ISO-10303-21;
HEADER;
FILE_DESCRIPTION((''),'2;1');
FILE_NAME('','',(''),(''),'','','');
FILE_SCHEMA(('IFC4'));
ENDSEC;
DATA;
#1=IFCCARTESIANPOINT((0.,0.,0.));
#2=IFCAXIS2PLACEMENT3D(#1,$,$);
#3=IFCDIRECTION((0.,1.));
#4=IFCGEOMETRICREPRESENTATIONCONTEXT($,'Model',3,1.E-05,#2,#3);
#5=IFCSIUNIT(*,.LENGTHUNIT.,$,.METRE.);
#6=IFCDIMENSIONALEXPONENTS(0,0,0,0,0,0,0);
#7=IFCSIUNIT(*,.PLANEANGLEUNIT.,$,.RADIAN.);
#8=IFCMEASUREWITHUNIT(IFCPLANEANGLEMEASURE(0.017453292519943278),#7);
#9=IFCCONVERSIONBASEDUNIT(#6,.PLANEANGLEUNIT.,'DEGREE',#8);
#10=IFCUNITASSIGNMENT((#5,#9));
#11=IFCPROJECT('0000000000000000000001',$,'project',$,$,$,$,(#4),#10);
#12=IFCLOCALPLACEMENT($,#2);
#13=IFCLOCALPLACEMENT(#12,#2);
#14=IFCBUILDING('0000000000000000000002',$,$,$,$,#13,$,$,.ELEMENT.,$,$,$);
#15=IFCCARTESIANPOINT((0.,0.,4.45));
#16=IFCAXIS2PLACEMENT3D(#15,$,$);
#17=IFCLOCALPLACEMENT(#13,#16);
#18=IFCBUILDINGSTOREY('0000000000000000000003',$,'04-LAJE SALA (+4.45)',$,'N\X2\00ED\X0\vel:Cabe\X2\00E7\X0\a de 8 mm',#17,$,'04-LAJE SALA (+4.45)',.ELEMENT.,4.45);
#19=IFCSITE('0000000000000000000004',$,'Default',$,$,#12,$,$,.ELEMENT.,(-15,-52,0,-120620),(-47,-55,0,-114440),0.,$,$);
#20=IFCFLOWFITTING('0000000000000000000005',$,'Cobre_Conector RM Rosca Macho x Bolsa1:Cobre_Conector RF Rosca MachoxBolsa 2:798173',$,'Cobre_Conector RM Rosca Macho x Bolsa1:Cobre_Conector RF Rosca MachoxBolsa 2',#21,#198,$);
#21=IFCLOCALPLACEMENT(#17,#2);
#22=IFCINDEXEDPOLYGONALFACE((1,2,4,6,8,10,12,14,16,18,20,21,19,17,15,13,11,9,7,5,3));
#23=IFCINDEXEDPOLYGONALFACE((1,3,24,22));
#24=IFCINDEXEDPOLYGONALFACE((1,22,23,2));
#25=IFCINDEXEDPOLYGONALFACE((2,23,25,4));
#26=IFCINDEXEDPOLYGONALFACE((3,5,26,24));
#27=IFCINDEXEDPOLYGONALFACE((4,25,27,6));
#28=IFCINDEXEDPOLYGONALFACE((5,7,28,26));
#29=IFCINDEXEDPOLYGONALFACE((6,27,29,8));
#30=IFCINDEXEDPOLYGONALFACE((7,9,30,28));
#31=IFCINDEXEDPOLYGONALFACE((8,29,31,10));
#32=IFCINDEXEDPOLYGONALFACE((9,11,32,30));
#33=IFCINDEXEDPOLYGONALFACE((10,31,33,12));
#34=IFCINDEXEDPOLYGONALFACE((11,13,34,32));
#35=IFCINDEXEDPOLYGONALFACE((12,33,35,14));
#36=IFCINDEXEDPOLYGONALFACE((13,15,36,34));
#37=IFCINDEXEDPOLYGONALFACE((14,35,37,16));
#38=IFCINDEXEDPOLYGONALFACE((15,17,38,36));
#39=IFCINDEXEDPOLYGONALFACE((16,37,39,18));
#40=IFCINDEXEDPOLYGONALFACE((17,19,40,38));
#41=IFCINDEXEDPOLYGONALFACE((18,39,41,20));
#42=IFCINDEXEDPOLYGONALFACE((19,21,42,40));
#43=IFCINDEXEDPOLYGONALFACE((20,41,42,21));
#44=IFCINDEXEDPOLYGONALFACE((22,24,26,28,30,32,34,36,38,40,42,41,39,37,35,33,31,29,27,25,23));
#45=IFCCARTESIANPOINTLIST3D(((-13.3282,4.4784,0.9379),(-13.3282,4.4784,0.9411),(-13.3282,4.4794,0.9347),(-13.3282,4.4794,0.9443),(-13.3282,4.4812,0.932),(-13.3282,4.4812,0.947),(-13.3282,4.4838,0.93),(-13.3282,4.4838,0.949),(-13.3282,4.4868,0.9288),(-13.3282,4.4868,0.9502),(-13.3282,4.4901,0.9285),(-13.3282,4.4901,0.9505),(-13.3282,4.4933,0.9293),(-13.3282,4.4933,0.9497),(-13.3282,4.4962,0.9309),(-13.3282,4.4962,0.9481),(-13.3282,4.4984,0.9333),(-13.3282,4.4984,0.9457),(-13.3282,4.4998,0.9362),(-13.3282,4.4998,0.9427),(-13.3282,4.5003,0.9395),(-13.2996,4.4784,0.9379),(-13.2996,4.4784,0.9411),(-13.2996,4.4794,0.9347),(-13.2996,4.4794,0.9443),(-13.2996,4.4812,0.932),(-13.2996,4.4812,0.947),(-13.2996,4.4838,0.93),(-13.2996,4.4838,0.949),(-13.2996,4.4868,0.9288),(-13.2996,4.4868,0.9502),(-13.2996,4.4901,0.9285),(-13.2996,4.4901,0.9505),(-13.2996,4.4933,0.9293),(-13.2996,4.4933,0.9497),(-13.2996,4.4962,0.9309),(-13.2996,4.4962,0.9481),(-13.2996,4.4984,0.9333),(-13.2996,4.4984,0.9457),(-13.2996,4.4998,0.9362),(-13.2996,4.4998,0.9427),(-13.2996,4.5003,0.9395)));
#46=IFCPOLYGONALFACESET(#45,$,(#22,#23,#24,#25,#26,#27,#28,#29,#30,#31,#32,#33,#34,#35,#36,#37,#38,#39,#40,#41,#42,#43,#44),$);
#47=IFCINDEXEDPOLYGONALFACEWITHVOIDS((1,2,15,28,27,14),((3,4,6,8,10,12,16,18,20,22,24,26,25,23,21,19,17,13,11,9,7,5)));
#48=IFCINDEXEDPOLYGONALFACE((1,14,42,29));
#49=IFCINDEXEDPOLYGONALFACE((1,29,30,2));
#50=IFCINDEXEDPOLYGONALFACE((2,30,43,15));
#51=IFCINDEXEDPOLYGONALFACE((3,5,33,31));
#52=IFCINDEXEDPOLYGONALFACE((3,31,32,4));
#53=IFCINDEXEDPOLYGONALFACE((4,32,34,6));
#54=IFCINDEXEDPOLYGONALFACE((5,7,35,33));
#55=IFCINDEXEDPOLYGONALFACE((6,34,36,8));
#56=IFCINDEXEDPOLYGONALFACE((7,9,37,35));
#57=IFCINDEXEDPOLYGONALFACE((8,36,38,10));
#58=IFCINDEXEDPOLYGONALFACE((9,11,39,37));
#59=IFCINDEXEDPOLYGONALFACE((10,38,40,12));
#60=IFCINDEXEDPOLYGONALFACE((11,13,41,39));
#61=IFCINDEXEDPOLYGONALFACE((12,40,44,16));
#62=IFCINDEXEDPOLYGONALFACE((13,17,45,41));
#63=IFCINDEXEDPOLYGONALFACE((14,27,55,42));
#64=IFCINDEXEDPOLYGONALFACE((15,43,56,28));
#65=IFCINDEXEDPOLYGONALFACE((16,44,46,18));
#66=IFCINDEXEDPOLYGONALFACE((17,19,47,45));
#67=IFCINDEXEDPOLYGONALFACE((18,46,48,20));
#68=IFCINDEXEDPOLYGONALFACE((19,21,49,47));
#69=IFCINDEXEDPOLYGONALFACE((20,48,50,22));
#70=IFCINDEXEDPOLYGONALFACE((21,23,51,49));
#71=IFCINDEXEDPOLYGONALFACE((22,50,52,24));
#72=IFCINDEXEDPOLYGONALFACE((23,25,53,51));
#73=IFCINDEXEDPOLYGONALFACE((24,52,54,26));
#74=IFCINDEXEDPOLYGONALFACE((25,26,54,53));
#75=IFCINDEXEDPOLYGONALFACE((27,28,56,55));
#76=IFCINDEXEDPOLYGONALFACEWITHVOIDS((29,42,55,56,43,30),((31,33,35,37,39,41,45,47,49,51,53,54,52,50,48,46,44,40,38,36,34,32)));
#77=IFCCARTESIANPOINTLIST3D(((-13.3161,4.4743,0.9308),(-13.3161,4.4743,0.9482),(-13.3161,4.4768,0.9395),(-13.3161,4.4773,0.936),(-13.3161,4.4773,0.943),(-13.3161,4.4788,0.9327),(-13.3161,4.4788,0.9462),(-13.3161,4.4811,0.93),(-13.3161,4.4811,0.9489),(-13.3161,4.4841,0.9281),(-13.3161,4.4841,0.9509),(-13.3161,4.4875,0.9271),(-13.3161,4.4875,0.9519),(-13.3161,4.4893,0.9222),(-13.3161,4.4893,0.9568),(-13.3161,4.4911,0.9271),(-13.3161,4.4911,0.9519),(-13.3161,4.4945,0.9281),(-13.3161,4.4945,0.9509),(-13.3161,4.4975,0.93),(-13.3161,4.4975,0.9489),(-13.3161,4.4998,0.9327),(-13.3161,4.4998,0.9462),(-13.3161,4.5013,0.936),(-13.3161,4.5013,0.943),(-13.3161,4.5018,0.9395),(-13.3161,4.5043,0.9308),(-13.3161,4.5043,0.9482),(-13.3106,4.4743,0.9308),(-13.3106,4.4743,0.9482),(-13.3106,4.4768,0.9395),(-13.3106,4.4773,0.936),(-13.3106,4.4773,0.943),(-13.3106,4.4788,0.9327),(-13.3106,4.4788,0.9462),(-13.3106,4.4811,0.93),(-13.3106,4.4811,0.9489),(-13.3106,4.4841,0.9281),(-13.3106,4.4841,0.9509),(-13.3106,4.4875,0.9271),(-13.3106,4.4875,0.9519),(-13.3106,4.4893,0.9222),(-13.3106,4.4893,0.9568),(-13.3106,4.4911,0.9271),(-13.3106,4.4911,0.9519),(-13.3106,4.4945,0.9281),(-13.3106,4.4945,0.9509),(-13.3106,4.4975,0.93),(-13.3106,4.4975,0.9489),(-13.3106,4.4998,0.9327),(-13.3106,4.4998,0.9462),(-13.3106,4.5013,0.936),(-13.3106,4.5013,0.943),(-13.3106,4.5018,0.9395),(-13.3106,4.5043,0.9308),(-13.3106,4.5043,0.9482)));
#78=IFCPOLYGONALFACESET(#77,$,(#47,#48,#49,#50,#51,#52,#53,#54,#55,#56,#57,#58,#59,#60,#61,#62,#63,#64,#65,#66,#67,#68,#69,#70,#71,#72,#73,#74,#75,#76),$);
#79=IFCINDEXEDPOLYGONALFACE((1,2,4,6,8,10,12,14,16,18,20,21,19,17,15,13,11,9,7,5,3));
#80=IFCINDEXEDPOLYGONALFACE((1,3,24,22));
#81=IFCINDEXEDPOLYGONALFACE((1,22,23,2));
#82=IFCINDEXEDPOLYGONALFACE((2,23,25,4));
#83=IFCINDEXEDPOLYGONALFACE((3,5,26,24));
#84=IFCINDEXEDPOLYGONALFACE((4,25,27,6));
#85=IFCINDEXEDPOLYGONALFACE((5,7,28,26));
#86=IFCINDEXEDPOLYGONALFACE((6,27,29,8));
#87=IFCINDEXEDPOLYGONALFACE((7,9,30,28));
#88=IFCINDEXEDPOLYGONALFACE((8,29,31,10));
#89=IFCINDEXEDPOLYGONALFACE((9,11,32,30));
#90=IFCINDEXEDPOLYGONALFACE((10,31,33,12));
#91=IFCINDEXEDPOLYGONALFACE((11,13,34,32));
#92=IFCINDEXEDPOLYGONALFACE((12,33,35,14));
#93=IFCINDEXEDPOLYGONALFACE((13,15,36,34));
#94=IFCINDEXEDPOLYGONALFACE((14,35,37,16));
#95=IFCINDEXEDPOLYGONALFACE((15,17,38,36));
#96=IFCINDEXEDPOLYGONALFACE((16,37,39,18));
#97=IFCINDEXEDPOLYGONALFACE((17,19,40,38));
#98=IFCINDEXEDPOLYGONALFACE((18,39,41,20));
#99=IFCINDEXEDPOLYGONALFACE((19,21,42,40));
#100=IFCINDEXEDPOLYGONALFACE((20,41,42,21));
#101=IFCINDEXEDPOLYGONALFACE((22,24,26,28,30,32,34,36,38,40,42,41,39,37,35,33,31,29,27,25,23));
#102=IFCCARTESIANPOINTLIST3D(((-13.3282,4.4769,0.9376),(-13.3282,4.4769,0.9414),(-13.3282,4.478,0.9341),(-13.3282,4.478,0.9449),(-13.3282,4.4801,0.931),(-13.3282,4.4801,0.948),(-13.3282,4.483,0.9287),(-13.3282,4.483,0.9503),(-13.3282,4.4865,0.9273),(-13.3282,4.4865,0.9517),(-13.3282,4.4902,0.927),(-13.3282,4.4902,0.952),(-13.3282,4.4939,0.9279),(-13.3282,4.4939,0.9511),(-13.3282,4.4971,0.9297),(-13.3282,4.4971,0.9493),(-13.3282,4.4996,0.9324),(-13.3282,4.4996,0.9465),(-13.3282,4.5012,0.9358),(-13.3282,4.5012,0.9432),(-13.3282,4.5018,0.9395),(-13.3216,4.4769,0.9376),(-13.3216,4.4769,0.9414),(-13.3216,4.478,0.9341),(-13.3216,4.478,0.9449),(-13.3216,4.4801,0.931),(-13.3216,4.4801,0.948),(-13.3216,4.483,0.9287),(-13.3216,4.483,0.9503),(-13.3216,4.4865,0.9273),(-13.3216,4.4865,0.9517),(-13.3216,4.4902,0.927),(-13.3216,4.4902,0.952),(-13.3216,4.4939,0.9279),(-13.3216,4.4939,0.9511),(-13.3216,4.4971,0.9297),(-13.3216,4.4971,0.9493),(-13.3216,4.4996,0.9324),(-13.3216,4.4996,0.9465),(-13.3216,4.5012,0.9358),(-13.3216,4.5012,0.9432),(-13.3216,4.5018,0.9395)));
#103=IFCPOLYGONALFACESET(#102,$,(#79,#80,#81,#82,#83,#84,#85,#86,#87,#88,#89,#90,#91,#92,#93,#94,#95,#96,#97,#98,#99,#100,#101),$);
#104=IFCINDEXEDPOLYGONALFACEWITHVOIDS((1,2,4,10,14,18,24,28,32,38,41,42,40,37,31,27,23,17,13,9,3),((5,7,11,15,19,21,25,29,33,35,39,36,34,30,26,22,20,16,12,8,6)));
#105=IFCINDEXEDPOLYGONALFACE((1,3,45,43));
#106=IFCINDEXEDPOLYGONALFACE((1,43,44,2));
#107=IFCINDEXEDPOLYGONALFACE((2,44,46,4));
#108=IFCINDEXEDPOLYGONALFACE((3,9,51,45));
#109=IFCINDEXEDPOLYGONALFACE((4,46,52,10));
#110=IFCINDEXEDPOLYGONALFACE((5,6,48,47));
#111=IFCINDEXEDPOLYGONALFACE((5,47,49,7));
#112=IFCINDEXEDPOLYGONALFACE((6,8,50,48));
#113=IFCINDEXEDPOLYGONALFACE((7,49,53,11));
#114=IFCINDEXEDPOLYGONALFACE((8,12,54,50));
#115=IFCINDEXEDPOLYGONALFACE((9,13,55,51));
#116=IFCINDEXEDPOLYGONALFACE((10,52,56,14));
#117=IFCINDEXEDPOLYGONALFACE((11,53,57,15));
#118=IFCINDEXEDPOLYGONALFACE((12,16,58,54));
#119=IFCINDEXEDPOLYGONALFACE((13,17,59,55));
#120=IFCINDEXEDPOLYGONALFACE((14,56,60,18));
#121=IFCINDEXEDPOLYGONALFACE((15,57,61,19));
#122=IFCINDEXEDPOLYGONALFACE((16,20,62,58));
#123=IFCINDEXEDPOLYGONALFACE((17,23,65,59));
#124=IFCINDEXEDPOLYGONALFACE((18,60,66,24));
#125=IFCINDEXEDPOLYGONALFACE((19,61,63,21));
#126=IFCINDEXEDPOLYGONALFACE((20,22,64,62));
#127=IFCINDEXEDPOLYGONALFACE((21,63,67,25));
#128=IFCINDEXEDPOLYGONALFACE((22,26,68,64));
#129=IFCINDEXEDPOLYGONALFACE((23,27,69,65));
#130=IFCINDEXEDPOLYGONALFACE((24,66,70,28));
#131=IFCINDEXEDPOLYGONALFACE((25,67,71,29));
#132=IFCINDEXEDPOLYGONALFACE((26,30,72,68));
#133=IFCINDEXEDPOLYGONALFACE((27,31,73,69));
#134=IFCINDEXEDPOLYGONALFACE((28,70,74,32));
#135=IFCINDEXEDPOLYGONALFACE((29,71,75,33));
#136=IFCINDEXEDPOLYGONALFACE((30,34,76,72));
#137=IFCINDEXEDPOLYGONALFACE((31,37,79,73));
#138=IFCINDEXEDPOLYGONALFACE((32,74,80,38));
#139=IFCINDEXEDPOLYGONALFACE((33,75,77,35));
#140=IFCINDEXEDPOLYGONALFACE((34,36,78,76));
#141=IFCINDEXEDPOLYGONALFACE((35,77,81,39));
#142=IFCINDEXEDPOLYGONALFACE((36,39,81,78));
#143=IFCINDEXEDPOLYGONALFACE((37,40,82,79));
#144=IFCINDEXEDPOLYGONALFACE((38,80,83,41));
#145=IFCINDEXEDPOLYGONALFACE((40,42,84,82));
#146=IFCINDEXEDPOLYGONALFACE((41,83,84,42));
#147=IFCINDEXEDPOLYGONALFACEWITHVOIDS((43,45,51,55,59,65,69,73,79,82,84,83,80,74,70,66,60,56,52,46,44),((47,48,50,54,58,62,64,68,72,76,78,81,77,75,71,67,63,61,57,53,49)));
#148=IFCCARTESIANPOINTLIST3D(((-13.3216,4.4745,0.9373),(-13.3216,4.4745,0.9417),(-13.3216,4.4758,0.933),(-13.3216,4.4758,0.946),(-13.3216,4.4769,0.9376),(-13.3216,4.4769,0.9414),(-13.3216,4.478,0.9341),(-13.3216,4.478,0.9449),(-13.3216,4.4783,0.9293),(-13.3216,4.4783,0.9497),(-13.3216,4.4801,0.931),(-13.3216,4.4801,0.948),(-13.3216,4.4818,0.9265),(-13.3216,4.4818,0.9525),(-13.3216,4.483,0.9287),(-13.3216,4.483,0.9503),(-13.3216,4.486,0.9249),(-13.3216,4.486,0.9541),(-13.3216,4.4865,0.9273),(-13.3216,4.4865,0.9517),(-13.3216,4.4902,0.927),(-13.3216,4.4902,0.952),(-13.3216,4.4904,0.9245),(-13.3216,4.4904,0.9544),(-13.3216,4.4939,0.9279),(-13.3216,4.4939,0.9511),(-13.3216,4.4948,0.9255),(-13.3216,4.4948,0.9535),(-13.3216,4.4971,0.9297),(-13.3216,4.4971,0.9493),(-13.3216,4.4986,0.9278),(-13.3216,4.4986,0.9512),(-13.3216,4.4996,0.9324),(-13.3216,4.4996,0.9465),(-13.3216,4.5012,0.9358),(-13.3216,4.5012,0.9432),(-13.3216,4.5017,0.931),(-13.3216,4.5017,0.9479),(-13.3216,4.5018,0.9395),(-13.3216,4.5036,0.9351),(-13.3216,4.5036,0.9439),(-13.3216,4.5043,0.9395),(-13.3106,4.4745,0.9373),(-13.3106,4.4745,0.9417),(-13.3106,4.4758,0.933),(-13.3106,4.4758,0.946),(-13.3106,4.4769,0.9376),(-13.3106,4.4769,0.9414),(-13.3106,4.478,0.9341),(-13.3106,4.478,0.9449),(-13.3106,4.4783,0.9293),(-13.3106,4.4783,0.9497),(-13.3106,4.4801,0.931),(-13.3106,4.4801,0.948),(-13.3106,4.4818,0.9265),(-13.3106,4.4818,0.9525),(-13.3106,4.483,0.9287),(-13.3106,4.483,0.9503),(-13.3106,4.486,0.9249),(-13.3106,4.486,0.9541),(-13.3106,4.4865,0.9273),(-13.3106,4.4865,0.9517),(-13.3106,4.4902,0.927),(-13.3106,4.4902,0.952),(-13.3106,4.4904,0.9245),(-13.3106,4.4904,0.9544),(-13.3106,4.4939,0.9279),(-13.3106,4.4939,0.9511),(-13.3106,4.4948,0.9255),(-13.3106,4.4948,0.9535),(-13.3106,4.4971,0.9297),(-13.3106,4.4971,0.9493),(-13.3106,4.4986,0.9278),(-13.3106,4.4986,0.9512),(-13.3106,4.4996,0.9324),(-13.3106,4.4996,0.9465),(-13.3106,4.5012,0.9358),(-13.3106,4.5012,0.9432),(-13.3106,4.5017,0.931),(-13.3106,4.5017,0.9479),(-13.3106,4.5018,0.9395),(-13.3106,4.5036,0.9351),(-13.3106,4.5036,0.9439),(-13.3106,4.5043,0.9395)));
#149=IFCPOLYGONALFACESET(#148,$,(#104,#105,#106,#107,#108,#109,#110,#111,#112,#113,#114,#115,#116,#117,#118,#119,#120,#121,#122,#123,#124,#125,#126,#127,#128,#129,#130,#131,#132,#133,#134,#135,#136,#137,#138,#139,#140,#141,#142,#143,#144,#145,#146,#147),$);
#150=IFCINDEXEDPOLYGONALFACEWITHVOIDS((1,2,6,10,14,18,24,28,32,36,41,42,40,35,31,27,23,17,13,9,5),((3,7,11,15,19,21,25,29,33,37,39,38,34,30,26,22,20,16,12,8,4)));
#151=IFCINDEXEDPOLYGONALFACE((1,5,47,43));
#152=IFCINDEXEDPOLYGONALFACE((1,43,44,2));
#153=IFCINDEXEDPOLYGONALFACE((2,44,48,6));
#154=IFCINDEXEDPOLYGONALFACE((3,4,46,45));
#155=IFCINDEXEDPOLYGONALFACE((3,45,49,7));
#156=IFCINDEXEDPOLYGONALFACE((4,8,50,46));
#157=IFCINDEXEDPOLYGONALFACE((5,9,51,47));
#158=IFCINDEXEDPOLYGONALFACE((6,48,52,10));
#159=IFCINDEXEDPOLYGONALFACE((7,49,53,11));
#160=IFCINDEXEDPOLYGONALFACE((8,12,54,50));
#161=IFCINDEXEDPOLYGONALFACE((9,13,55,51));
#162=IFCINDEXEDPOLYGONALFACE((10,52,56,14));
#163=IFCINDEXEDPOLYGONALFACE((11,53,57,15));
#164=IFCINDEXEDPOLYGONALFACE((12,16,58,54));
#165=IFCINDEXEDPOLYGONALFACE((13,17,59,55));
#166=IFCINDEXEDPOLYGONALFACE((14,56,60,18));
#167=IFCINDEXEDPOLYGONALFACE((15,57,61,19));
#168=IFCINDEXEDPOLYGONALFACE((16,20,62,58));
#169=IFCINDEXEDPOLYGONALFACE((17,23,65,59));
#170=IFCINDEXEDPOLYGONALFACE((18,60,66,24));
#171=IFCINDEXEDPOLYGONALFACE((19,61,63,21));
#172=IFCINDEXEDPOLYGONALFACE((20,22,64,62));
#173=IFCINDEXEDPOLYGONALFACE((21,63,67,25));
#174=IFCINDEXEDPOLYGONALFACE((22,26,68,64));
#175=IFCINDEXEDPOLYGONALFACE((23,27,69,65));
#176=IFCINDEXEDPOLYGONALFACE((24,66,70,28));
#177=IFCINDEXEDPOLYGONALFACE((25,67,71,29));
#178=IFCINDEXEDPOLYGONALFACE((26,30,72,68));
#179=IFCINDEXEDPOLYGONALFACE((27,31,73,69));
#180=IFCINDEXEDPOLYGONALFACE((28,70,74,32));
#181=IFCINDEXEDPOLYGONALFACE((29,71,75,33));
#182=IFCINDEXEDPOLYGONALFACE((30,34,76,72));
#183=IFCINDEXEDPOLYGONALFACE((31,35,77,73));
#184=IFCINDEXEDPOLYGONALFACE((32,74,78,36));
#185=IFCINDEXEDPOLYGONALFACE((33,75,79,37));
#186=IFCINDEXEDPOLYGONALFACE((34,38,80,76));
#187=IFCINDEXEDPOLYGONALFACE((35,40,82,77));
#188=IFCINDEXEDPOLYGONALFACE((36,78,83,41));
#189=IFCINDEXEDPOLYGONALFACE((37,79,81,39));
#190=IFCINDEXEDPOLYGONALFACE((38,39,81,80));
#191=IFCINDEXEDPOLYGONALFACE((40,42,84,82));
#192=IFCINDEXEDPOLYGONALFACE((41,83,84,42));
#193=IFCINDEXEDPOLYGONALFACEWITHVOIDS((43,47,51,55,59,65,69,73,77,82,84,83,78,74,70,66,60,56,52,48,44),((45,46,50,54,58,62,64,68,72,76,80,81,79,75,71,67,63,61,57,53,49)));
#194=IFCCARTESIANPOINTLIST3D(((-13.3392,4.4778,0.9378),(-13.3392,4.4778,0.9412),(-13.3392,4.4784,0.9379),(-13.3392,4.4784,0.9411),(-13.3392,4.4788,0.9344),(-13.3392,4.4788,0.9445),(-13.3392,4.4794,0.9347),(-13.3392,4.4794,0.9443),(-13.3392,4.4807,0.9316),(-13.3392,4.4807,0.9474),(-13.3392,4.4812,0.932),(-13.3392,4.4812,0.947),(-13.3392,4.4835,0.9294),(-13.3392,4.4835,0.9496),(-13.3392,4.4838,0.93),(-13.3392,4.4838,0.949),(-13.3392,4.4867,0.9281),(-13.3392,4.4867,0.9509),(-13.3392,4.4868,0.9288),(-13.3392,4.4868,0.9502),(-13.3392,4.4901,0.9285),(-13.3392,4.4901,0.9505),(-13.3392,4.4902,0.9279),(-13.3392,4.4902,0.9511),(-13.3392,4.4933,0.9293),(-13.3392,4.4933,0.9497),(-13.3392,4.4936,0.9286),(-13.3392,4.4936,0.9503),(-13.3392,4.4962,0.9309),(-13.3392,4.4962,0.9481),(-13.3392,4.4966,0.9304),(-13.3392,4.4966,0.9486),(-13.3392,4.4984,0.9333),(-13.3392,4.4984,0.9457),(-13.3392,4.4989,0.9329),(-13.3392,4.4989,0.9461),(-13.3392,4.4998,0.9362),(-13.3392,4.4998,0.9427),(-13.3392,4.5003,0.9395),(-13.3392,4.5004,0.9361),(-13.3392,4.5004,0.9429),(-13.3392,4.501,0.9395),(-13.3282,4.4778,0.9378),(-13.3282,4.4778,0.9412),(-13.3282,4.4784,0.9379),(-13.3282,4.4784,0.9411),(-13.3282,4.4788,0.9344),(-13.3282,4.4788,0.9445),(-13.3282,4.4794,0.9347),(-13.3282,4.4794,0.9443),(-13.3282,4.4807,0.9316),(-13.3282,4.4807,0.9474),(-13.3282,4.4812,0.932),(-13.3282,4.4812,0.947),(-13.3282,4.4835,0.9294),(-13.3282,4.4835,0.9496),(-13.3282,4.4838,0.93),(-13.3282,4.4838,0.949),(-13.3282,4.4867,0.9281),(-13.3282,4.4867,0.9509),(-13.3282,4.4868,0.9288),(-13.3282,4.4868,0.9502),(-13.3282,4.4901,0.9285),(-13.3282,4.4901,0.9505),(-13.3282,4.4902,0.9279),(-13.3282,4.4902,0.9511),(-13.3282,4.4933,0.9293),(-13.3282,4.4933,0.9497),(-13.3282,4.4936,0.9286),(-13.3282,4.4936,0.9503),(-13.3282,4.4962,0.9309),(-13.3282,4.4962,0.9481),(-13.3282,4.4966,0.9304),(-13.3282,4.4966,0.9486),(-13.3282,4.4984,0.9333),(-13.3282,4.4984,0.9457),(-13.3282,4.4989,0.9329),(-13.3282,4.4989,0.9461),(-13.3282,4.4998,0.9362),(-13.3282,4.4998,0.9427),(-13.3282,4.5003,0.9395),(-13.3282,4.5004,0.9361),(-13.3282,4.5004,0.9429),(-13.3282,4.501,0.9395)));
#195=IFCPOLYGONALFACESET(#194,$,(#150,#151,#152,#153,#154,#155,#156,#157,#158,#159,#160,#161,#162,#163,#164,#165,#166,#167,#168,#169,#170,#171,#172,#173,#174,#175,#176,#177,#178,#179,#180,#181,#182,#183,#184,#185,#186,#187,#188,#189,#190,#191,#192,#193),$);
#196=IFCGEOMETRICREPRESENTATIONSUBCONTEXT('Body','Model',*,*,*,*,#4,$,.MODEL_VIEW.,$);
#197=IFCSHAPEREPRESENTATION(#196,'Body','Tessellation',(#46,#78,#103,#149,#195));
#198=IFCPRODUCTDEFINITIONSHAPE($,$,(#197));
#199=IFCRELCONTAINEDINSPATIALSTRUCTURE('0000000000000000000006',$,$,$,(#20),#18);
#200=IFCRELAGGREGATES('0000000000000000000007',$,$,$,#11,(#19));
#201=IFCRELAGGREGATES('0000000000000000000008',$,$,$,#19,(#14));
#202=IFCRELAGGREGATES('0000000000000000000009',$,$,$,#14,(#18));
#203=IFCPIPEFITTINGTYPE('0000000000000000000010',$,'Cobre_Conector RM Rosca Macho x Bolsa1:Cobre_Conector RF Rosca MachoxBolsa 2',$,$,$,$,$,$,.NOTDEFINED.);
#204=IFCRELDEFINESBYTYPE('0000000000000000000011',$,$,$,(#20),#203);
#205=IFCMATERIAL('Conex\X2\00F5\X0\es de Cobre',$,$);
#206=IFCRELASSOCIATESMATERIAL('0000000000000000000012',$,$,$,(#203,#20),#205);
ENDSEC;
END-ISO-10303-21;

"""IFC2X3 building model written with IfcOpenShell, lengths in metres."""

from ifc_helpers import new_model, entity, si_unit, converted_unit, direction, frame, frame_2d, origin, place, context, subcontext, project, spatial, polyline, circle_curve, parameter, trimmed, segment, composite_curve, circle, hollow_circle, outline, extrude, source, transform, mapped, material, type_object, type_shapes, element, save


model = new_model("IFC2X3")

# Units and contexts
model_context = context("Model", 3, precision=1e-05, world=origin(), true_north=direction((0.0, 1.0)))
body_context = subcontext(model_context, "Body", "Model", "MODEL_VIEW")
ifc_project = project(units=[si_unit("LENGTHUNIT", "METRE"), converted_unit("PLANEANGLEUNIT", "DEGREE", entity("IfcPlaneAngleMeasure", 0.017453292519943278), si_unit("PLANEANGLEUNIT", "RADIAN"), dimensions=[0, 0, 0, 0, 0, 0, 0])], contexts=[model_context])

# Site, building, storey
site_placement = place(None, origin())
site = spatial("IfcSite", under=ifc_project, at=site_placement, Name="Default", CompositionType="ELEMENT", RefLatitude=(-15, -52, 0, -120620), RefLongitude=(-47, -55, 0, -114440), RefElevation=0.0)
building_placement = place(site_placement, origin())
building = spatial("IfcBuilding", under=site, at=building_placement, CompositionType="ELEMENT")
storey_placement = place(building_placement, frame((0.0, 0.0, 4.45)))
storey = spatial("IfcBuildingStorey", under=building, at=storey_placement, Name="04-LAJE SALA (+4.45)", ObjectType="Nível:Cabeça de 8 mm", LongName="04-LAJE SALA (+4.45)", CompositionType="ELEMENT", Elevation=4.45)

# Flow fitting
ifc_material_1 = material(Name="Conexões de Cobre")
pipe_fitting_type_1 = type_object("IfcPipeFittingType", Name="Cobre_Conector RM Rosca Macho x Bolsa1:Cobre_Conector RF Rosca MachoxBolsa 2", PredefinedType="NOTDEFINED", material=ifc_material_1)
shared_shape_1 = source(origin(), body_context, "Body", "SweptSolid", [
    extrude(circle(Radius=0.011, at=frame_2d((0.0, 0.0), x_axis=(1.0, 0.0))), frame((0.011, 0.0, 0.0), z_axis=(1.0, 0.0, 0.0), x_axis=(0.0, 1.0, 0.0)), (0.0, 0.0, 1.0), 0.0286),
    extrude(outline(polyline([(-0.0087, -0.015), (0.0087, -0.015), (0.0173, 0.0), (0.0087, 0.015), (-0.0087, 0.015), (-0.0173, 0.0), (-0.0087, -0.015)]), holes=[composite_curve([segment(trimmed(circle_curve(frame_2d((0.0, 0.0), x_axis=(0.0, 1.0)), 0.0125), [parameter(0.0)], [parameter(180.0)], True, "PARAMETER"), False, "CONTINUOUS"), segment(trimmed(circle_curve(frame_2d((0.0, 0.0), x_axis=(0.0, 1.0)), 0.0125), [parameter(180.0)], [parameter(0.0)], True, "PARAMETER"), False, "CONTINUOUS")], self_intersect=False)]), frame((0.0231, 0.0, 0.0), z_axis=(1.0, 0.0, 0.0), x_axis=(0.0, 0.0, -1.0)), (0.0, 0.0, 1.0), 0.0055),
    extrude(circle(Radius=0.0125, at=frame_2d((0.0, 0.0), x_axis=(1.0, 0.0))), frame((0.011, 0.0, 0.0), z_axis=(1.0, 0.0, 0.0), x_axis=(0.0, 1.0, 0.0)), (0.0, 0.0, 1.0), 0.0066),
    extrude(hollow_circle(Radius=0.015, WallThickness=0.0025, at=frame_2d((0.0, 0.0), x_axis=(1.0, 0.0))), frame((0.0176, 0.0, 0.0), z_axis=(1.0, 0.0, 0.0), x_axis=(0.0, 1.0, 0.0)), (0.0, 0.0, 1.0), 0.011),
    extrude(hollow_circle(Radius=0.0117, WallThickness=0.0007, at=frame_2d((0.0, 0.0), x_axis=(1.0, 0.0))), frame((0.0, 0.0, 0.0), z_axis=(1.0, 0.0, 0.0), x_axis=(0.0, 1.0, 0.0)), (0.0, 0.0, 1.0), 0.011),
])
type_shapes(pipe_fitting_type_1, [shared_shape_1])
flow_fitting_1_placement = place(storey_placement, frame((-13.3392, 4.4893, 0.9395)))
element("IfcFlowFitting", 1, at=flow_fitting_1_placement, inside=storey, type_object=pipe_fitting_type_1, material=ifc_material_1, Name="Cobre_Conector RM Rosca Macho x Bolsa1:Cobre_Conector RF Rosca MachoxBolsa 2:798173", ObjectType="Cobre_Conector RM Rosca Macho x Bolsa1:Cobre_Conector RF Rosca MachoxBolsa 2", context=body_context, shape_type="MappedRepresentation", body=[
    mapped(shared_shape_1, transform((0.0, 0.0, 0.0), scale=1.0)),
])

save(model, "model.ifc")
